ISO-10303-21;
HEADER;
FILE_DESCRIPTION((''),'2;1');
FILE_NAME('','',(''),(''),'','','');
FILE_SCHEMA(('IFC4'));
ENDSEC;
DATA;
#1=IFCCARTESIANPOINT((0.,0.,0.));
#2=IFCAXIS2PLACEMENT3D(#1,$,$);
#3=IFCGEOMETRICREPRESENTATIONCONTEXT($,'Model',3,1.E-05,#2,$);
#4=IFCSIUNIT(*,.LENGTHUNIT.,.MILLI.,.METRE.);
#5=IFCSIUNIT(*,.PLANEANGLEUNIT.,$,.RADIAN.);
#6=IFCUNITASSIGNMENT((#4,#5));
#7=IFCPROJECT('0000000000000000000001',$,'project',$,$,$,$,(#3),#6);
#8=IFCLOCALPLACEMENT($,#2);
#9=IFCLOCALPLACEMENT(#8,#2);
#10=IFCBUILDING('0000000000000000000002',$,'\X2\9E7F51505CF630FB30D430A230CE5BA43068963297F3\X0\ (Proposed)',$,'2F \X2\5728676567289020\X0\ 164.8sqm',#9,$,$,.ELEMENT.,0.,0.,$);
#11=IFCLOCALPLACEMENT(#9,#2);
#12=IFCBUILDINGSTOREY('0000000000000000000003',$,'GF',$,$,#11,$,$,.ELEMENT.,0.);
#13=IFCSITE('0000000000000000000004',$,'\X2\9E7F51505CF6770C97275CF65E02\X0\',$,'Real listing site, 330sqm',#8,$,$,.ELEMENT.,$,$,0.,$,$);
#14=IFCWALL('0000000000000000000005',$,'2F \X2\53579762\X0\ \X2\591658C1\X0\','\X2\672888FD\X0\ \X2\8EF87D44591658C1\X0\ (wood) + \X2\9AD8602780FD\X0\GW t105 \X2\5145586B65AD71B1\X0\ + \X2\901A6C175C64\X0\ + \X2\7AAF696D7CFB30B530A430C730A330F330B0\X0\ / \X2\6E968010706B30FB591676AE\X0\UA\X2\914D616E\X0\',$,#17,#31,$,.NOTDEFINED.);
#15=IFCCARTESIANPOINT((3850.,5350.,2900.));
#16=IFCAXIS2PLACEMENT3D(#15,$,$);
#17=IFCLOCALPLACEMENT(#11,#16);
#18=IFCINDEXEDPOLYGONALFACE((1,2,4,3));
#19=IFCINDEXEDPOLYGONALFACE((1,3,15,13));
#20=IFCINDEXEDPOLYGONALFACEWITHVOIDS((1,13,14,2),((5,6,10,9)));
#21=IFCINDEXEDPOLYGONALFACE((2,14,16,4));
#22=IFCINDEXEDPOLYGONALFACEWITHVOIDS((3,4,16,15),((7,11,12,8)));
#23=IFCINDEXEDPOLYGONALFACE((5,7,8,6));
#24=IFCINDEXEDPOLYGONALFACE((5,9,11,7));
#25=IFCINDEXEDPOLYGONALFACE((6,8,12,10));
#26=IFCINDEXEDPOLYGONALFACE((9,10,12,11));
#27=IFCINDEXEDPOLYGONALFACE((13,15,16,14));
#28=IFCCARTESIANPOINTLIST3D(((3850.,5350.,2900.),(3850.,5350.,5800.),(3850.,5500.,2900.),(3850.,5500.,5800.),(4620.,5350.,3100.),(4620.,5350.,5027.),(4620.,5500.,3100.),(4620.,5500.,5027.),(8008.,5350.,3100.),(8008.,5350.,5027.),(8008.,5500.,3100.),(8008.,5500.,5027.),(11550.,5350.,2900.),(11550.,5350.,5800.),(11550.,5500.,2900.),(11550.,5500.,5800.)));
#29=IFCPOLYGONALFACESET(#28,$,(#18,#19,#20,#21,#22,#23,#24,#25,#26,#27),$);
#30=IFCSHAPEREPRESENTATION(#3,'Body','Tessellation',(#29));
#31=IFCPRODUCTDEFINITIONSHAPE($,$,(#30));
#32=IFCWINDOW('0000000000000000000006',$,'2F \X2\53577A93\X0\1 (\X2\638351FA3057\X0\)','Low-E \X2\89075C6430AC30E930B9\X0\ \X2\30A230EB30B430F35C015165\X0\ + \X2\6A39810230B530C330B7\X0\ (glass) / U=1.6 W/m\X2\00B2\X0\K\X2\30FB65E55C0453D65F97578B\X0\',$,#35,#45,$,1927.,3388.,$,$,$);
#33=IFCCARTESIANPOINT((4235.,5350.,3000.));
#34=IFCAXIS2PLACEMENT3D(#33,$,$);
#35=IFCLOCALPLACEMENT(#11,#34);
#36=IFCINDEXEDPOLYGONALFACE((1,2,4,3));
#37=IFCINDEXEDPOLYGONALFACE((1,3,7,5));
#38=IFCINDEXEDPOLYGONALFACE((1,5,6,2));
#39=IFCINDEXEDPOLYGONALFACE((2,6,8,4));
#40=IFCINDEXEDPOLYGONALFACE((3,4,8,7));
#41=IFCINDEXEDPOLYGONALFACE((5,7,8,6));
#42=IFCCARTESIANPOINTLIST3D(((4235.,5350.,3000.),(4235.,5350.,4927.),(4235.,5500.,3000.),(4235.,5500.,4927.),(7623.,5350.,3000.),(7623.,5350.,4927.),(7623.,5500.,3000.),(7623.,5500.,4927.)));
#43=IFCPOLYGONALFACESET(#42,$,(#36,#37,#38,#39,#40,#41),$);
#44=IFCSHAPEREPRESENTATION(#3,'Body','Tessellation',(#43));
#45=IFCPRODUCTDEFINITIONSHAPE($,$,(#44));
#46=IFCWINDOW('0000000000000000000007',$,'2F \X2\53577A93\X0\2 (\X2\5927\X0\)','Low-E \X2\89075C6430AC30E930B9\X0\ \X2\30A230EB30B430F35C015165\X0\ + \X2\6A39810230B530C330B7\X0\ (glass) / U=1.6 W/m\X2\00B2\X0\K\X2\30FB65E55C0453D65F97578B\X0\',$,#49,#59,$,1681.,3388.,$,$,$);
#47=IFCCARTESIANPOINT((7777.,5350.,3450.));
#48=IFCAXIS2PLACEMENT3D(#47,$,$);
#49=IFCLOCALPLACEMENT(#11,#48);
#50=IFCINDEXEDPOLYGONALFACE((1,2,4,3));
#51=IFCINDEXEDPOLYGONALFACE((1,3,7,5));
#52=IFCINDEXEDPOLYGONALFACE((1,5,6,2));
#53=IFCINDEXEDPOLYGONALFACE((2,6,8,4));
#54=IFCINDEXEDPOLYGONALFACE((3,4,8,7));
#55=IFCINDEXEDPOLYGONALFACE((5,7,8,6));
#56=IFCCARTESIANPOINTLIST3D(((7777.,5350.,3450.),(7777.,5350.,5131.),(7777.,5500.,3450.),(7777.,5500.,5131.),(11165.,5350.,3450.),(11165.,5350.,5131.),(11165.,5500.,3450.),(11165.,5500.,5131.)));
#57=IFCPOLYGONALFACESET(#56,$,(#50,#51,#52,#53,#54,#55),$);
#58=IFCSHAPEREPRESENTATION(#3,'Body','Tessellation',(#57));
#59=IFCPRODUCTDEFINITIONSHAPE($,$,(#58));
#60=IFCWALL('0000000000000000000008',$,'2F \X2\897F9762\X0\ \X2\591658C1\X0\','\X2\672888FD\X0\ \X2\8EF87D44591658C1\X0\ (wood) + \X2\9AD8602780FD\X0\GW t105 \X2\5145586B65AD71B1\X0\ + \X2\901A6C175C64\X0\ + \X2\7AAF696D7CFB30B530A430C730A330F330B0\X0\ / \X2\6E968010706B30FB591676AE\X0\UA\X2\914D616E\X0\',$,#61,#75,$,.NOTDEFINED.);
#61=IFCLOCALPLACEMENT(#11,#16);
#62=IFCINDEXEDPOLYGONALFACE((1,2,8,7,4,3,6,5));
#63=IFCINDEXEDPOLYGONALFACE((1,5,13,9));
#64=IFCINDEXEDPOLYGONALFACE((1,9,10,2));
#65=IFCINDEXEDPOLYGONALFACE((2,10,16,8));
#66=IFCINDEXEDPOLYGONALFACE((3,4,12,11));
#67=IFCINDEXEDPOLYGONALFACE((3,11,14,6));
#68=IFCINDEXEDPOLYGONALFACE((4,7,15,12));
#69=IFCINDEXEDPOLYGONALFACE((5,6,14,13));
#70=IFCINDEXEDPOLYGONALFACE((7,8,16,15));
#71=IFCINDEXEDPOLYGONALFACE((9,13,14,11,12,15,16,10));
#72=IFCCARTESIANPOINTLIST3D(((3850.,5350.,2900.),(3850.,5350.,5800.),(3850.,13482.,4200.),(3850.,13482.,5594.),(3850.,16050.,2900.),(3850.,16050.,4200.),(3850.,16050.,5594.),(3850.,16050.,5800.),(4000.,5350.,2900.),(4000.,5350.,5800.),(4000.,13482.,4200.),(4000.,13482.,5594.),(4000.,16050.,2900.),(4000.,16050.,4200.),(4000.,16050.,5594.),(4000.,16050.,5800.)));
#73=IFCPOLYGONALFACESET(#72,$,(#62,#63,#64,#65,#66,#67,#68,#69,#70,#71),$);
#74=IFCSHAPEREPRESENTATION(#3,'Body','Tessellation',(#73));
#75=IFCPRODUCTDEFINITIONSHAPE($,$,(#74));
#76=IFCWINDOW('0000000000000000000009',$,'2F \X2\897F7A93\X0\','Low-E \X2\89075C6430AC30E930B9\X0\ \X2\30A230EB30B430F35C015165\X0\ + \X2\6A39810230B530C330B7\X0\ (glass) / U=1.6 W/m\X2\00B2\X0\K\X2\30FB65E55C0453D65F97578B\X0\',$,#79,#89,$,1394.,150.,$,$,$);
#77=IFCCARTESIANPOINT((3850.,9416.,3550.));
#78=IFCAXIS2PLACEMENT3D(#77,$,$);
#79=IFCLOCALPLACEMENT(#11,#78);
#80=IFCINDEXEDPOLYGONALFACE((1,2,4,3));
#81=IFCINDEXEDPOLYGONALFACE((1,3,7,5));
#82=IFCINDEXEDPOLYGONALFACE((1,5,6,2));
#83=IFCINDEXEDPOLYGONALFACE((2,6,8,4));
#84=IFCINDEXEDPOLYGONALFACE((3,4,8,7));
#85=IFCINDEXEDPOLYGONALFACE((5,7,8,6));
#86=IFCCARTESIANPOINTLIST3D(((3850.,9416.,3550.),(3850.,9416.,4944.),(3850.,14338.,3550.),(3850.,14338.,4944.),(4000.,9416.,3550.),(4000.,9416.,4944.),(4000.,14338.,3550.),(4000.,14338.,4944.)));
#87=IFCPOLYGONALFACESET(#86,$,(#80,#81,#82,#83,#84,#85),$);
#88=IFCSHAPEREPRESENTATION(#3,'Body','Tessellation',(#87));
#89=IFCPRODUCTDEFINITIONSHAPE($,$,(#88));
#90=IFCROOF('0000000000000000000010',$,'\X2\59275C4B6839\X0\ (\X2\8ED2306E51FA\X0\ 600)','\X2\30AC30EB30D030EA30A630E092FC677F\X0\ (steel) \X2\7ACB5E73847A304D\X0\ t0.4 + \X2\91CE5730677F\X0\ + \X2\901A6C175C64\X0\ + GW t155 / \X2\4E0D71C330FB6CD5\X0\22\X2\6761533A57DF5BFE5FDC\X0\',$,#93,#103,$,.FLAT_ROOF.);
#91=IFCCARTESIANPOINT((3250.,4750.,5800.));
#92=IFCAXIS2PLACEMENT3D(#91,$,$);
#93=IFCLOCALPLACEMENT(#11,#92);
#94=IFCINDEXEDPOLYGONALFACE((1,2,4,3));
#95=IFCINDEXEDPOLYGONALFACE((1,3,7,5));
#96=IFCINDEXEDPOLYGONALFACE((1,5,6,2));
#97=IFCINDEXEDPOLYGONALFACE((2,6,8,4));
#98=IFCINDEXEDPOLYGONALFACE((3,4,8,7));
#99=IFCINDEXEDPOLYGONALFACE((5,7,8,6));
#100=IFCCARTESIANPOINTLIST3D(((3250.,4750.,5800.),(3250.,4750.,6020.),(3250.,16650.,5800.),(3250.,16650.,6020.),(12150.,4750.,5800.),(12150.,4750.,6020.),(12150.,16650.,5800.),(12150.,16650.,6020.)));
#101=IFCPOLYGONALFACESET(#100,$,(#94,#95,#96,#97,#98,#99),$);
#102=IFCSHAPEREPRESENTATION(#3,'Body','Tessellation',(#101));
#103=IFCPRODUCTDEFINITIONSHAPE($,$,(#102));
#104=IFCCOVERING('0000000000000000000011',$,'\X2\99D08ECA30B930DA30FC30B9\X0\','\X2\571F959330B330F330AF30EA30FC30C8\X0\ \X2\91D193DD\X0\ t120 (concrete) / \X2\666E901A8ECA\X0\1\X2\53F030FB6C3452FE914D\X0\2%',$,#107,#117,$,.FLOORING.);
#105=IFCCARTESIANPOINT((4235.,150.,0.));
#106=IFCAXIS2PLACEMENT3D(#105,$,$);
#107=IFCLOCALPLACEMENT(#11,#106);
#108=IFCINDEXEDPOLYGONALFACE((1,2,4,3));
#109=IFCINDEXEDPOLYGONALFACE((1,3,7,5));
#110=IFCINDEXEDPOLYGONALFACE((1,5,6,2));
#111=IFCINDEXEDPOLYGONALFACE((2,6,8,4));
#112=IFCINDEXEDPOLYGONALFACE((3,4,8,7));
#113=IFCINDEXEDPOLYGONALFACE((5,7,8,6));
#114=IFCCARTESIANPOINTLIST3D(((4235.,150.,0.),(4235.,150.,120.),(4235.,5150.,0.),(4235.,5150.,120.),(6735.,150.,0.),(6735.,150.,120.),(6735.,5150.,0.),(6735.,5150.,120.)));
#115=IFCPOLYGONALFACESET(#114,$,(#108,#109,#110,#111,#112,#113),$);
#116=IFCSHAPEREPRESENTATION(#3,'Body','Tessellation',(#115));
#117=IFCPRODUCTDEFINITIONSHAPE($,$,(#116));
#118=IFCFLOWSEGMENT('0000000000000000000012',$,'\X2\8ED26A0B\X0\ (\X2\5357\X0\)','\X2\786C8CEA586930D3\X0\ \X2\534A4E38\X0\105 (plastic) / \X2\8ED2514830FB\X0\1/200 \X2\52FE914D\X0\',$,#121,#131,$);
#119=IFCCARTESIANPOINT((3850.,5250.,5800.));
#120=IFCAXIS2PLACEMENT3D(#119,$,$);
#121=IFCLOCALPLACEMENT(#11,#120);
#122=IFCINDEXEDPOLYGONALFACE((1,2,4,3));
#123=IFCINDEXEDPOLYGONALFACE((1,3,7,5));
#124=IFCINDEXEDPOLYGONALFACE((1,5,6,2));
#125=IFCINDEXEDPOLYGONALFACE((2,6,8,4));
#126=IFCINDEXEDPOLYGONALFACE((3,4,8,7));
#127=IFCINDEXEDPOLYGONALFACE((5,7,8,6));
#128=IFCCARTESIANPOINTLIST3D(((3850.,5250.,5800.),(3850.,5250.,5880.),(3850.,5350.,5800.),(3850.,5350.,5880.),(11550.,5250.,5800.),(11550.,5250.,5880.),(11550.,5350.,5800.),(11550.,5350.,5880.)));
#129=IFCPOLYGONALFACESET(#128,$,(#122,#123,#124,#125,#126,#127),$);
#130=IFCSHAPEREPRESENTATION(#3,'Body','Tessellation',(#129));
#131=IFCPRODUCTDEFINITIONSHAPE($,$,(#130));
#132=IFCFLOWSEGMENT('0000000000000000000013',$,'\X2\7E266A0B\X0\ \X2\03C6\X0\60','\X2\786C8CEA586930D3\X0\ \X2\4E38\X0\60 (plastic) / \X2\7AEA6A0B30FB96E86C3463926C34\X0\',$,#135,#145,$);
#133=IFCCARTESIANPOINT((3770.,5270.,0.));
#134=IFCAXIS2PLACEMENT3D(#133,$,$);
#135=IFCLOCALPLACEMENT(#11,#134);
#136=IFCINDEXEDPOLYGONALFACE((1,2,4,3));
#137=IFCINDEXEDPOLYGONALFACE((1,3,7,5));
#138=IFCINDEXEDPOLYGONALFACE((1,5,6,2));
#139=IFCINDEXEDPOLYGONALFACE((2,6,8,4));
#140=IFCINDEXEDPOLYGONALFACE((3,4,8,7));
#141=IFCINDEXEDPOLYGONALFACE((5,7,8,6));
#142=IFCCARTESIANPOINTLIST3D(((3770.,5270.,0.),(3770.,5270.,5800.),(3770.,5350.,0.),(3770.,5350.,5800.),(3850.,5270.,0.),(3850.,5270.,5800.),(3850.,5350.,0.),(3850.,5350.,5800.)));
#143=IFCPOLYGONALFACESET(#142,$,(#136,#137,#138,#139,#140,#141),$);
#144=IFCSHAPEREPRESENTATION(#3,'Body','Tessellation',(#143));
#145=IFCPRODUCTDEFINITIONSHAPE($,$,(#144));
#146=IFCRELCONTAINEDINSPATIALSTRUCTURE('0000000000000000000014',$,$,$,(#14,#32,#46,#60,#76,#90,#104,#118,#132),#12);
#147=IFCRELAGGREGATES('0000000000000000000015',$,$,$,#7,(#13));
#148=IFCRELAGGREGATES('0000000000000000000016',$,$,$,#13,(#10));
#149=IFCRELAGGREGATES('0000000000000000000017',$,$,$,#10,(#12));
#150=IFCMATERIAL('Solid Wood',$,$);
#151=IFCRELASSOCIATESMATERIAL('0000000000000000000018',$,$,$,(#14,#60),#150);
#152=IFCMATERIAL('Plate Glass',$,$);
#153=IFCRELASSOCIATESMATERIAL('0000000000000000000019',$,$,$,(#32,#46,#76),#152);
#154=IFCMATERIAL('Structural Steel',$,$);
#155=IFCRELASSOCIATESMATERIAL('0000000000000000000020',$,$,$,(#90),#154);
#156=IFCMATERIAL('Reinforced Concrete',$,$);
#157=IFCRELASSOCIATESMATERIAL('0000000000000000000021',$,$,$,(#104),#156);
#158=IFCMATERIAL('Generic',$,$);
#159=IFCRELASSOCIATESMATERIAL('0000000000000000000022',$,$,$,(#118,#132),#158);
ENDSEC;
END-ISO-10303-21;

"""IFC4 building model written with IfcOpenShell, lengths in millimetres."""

from ifc_helpers import new_model, si_unit, frame, frame_2d, origin, place, context, project, spatial, rectangle, extrude, material, element, fill, save


model = new_model("IFC4")

# Units and contexts
model_context = context("Model", 3, precision=1e-05, world=origin())
ifc_project = project(units=[si_unit("LENGTHUNIT", "METRE", prefix="MILLI"), si_unit("PLANEANGLEUNIT", "RADIAN")], contexts=[model_context])

# Site, building, storey
site_placement = place(None, origin())
site = spatial("IfcSite", under=ifc_project, at=site_placement, Name="鹿児島県霧島市", ObjectType="Real listing site, 330sqm", CompositionType="ELEMENT", RefElevation=0.0)
building_placement = place(site_placement, origin())
building = spatial("IfcBuilding", under=site, at=building_placement, Name="鹿児島・ピアノ室と防音 (Proposed)", ObjectType="2F 在来木造 164.8sqm", CompositionType="ELEMENT", ElevationOfRefHeight=0.0, ElevationOfTerrain=0.0)
storey_placement = place(building_placement, origin())
storey = spatial("IfcBuildingStorey", under=building, at=storey_placement, Name="GF", CompositionType="ELEMENT", Elevation=0.0)

# Shared definitions
ifc_material_1 = material(Name="Solid Wood")

# Shared definitions
ifc_material_2 = material(Name="Reinforced Concrete")

# Shared definitions
ifc_material_3 = material(Name="Plate Glass")

# Wall, openings, windows
wall_1_placement = place(storey_placement, frame((3850.0, 5350.0, 2900.0)))
wall_1 = element("IfcWall", 1, at=wall_1_placement, inside=storey, material=ifc_material_1, Name="2F 南面 外壁", Description="木製 軸組外壁 (wood) + 高性能GW t105 充填断熱 + 通気層 + 窯業系サイディング / 準耐火・外皮UA配慮", PredefinedType="NOTDEFINED", context=model_context, shape_type="SweptSolid", body=[
    extrude(rectangle(XDim=7700.0, YDim=150.0, at=frame_2d((3850.0, 75.0))), frame((3850.0, 5350.0, 2900.0)), (0.0, 0.0, 1.0), 2900.0),
])
opening_1_placement = place(storey_placement, frame((4235.0, 5350.0, 3000.0)))
opening_1 = element("IfcOpeningElement", 2, at=opening_1_placement, cuts=wall_1, PredefinedType="NOTDEFINED", context=model_context, shape_type="SweptSolid", body=[
    extrude(rectangle(XDim=3388.0, YDim=150.0, at=frame_2d((1694.0, 75.0))), frame((4235.0, 5350.0, 3000.0)), (0.0, 0.0, 1.0), 1927.0),
])
opening_2_placement = place(storey_placement, frame((7777.0, 5350.0, 3450.0)))
opening_2 = element("IfcOpeningElement", 3, at=opening_2_placement, cuts=wall_1, PredefinedType="NOTDEFINED", context=model_context, shape_type="SweptSolid", body=[
    extrude(rectangle(XDim=3388.0, YDim=150.0, at=frame_2d((1694.0, 75.0))), frame((7777.0, 5350.0, 3450.0)), (0.0, 0.0, 1.0), 1681.0),
])
window_1_placement = place(storey_placement, frame((4235.0, 5350.0, 3000.0)))
window_1 = element("IfcWindow", 4, at=window_1_placement, inside=storey, material=ifc_material_3, Name="2F 南窓1 (掃出し)", Description="Low-E 複層ガラス アルゴン封入 + 樹脂サッシ (glass) / U=1.6 W/m²K・日射取得型", OverallHeight=1927.0, OverallWidth=3388.0, context=model_context, shape_type="SweptSolid", body=[
    extrude(rectangle(XDim=3388.0, YDim=150.0, at=frame_2d((1694.0, 75.0))), frame((4235.0, 5350.0, 3000.0)), (0.0, 0.0, 1.0), 1927.0),
])
fill(opening_1, window_1)
window_2_placement = place(storey_placement, frame((7777.0, 5350.0, 3450.0)))
window_2 = element("IfcWindow", 5, at=window_2_placement, inside=storey, material=ifc_material_3, Name="2F 南窓2 (大)", Description="Low-E 複層ガラス アルゴン封入 + 樹脂サッシ (glass) / U=1.6 W/m²K・日射取得型", OverallHeight=1681.0, OverallWidth=3388.0, context=model_context, shape_type="SweptSolid", body=[
    extrude(rectangle(XDim=3388.0, YDim=150.0, at=frame_2d((1694.0, 75.0))), frame((7777.0, 5350.0, 3450.0)), (0.0, 0.0, 1.0), 1681.0),
])
fill(opening_2, window_2)

# Wall, opening, window
wall_2_placement = place(storey_placement, frame((3850.0, 5350.0, 2900.0)))
wall_2 = element("IfcWall", 6, at=wall_2_placement, inside=storey, material=ifc_material_1, Name="2F 西面 外壁", Description="木製 軸組外壁 (wood) + 高性能GW t105 充填断熱 + 通気層 + 窯業系サイディング / 準耐火・外皮UA配慮", PredefinedType="NOTDEFINED", context=model_context, shape_type="SweptSolid", body=[
    extrude(rectangle(XDim=150.0, YDim=10700.0, at=frame_2d((75.0, 5350.0))), frame((3850.0, 5350.0, 2900.0)), (0.0, 0.0, 1.0), 2900.0),
])
opening_3_placement = place(storey_placement, frame((3850.0, 9416.0, 3550.0)))
opening_3 = element("IfcOpeningElement", 7, at=opening_3_placement, cuts=wall_2, PredefinedType="NOTDEFINED", context=model_context, shape_type="SweptSolid", body=[
    extrude(rectangle(XDim=150.0, YDim=4922.0, at=frame_2d((75.0, 2461.0))), frame((3850.0, 9416.0, 3550.0)), (0.0, 0.0, 1.0), 1394.0),
])
window_3_placement = place(storey_placement, frame((3850.0, 9416.0, 3550.0)))
window_3 = element("IfcWindow", 8, at=window_3_placement, inside=storey, material=ifc_material_3, Name="2F 西窓", Description="Low-E 複層ガラス アルゴン封入 + 樹脂サッシ (glass) / U=1.6 W/m²K・日射取得型", OverallHeight=1394.0, OverallWidth=150.0, context=model_context, shape_type="SweptSolid", body=[
    extrude(rectangle(XDim=150.0, YDim=4922.0, at=frame_2d((75.0, 2461.0))), frame((3850.0, 9416.0, 3550.0)), (0.0, 0.0, 1.0), 1394.0),
])
fill(opening_3, window_3)

# Roof
ifc_material_4 = material(Name="Structural Steel")
roof_placement = place(storey_placement, frame((3250.0, 4750.0, 5800.0)))
element("IfcRoof", 9, at=roof_placement, inside=storey, material=ifc_material_4, Name="大屋根 (軒の出 600)", Description="ガルバリウム鋼板 (steel) 立平葺き t0.4 + 野地板 + 通気層 + GW t155 / 不燃・法22条区域対応", PredefinedType="FLAT_ROOF", context=model_context, shape_type="SweptSolid", body=[
    extrude(rectangle(XDim=8900.0, YDim=11900.0, at=frame_2d((4450.0, 5950.0))), frame((3250.0, 4750.0, 5800.0)), (0.0, 0.0, 1.0), 220.0),
])

# Covering
covering_placement = place(storey_placement, frame((4235.0, 150.0, 0.0)))
element("IfcCovering", 10, at=covering_placement, inside=storey, material=ifc_material_2, Name="駐車スペース", Description="土間コンクリート 金鏝 t120 (concrete) / 普通車1台・水勾配2%", PredefinedType="FLOORING", context=model_context, shape_type="SweptSolid", body=[
    extrude(rectangle(XDim=2500.0, YDim=5000.0, at=frame_2d((1250.0, 2500.0))), frame((4235.0, 150.0, 0.0)), (0.0, 0.0, 1.0), 120.0),
])

# Flow segments
ifc_material_5 = material(Name="Generic")
flow_segment_1_placement = place(storey_placement, frame((3850.0, 5250.0, 5800.0)))
element("IfcFlowSegment", 11, at=flow_segment_1_placement, inside=storey, material=ifc_material_5, Name="軒樋 (南)", Description="硬質塩ビ 半丸105 (plastic) / 軒先・1/200 勾配", context=model_context, shape_type="SweptSolid", body=[
    extrude(rectangle(XDim=7700.0, YDim=100.0, at=frame_2d((3850.0, 50.0))), frame((3850.0, 5250.0, 5800.0)), (0.0, 0.0, 1.0), 80.0),
])
flow_segment_2_placement = place(storey_placement, frame((3770.0, 5270.0, 0.0)))
element("IfcFlowSegment", 12, at=flow_segment_2_placement, inside=storey, material=ifc_material_5, Name="縦樋 φ60", Description="硬質塩ビ 丸60 (plastic) / 竪樋・雨水排水", context=model_context, shape_type="SweptSolid", body=[
    extrude(rectangle(XDim=80.0, YDim=80.0, at=frame_2d((40.0, 40.0))), frame((3770.0, 5270.0, 0.0)), (0.0, 0.0, 1.0), 5800.0),
])

save(model, "model.ifc")
